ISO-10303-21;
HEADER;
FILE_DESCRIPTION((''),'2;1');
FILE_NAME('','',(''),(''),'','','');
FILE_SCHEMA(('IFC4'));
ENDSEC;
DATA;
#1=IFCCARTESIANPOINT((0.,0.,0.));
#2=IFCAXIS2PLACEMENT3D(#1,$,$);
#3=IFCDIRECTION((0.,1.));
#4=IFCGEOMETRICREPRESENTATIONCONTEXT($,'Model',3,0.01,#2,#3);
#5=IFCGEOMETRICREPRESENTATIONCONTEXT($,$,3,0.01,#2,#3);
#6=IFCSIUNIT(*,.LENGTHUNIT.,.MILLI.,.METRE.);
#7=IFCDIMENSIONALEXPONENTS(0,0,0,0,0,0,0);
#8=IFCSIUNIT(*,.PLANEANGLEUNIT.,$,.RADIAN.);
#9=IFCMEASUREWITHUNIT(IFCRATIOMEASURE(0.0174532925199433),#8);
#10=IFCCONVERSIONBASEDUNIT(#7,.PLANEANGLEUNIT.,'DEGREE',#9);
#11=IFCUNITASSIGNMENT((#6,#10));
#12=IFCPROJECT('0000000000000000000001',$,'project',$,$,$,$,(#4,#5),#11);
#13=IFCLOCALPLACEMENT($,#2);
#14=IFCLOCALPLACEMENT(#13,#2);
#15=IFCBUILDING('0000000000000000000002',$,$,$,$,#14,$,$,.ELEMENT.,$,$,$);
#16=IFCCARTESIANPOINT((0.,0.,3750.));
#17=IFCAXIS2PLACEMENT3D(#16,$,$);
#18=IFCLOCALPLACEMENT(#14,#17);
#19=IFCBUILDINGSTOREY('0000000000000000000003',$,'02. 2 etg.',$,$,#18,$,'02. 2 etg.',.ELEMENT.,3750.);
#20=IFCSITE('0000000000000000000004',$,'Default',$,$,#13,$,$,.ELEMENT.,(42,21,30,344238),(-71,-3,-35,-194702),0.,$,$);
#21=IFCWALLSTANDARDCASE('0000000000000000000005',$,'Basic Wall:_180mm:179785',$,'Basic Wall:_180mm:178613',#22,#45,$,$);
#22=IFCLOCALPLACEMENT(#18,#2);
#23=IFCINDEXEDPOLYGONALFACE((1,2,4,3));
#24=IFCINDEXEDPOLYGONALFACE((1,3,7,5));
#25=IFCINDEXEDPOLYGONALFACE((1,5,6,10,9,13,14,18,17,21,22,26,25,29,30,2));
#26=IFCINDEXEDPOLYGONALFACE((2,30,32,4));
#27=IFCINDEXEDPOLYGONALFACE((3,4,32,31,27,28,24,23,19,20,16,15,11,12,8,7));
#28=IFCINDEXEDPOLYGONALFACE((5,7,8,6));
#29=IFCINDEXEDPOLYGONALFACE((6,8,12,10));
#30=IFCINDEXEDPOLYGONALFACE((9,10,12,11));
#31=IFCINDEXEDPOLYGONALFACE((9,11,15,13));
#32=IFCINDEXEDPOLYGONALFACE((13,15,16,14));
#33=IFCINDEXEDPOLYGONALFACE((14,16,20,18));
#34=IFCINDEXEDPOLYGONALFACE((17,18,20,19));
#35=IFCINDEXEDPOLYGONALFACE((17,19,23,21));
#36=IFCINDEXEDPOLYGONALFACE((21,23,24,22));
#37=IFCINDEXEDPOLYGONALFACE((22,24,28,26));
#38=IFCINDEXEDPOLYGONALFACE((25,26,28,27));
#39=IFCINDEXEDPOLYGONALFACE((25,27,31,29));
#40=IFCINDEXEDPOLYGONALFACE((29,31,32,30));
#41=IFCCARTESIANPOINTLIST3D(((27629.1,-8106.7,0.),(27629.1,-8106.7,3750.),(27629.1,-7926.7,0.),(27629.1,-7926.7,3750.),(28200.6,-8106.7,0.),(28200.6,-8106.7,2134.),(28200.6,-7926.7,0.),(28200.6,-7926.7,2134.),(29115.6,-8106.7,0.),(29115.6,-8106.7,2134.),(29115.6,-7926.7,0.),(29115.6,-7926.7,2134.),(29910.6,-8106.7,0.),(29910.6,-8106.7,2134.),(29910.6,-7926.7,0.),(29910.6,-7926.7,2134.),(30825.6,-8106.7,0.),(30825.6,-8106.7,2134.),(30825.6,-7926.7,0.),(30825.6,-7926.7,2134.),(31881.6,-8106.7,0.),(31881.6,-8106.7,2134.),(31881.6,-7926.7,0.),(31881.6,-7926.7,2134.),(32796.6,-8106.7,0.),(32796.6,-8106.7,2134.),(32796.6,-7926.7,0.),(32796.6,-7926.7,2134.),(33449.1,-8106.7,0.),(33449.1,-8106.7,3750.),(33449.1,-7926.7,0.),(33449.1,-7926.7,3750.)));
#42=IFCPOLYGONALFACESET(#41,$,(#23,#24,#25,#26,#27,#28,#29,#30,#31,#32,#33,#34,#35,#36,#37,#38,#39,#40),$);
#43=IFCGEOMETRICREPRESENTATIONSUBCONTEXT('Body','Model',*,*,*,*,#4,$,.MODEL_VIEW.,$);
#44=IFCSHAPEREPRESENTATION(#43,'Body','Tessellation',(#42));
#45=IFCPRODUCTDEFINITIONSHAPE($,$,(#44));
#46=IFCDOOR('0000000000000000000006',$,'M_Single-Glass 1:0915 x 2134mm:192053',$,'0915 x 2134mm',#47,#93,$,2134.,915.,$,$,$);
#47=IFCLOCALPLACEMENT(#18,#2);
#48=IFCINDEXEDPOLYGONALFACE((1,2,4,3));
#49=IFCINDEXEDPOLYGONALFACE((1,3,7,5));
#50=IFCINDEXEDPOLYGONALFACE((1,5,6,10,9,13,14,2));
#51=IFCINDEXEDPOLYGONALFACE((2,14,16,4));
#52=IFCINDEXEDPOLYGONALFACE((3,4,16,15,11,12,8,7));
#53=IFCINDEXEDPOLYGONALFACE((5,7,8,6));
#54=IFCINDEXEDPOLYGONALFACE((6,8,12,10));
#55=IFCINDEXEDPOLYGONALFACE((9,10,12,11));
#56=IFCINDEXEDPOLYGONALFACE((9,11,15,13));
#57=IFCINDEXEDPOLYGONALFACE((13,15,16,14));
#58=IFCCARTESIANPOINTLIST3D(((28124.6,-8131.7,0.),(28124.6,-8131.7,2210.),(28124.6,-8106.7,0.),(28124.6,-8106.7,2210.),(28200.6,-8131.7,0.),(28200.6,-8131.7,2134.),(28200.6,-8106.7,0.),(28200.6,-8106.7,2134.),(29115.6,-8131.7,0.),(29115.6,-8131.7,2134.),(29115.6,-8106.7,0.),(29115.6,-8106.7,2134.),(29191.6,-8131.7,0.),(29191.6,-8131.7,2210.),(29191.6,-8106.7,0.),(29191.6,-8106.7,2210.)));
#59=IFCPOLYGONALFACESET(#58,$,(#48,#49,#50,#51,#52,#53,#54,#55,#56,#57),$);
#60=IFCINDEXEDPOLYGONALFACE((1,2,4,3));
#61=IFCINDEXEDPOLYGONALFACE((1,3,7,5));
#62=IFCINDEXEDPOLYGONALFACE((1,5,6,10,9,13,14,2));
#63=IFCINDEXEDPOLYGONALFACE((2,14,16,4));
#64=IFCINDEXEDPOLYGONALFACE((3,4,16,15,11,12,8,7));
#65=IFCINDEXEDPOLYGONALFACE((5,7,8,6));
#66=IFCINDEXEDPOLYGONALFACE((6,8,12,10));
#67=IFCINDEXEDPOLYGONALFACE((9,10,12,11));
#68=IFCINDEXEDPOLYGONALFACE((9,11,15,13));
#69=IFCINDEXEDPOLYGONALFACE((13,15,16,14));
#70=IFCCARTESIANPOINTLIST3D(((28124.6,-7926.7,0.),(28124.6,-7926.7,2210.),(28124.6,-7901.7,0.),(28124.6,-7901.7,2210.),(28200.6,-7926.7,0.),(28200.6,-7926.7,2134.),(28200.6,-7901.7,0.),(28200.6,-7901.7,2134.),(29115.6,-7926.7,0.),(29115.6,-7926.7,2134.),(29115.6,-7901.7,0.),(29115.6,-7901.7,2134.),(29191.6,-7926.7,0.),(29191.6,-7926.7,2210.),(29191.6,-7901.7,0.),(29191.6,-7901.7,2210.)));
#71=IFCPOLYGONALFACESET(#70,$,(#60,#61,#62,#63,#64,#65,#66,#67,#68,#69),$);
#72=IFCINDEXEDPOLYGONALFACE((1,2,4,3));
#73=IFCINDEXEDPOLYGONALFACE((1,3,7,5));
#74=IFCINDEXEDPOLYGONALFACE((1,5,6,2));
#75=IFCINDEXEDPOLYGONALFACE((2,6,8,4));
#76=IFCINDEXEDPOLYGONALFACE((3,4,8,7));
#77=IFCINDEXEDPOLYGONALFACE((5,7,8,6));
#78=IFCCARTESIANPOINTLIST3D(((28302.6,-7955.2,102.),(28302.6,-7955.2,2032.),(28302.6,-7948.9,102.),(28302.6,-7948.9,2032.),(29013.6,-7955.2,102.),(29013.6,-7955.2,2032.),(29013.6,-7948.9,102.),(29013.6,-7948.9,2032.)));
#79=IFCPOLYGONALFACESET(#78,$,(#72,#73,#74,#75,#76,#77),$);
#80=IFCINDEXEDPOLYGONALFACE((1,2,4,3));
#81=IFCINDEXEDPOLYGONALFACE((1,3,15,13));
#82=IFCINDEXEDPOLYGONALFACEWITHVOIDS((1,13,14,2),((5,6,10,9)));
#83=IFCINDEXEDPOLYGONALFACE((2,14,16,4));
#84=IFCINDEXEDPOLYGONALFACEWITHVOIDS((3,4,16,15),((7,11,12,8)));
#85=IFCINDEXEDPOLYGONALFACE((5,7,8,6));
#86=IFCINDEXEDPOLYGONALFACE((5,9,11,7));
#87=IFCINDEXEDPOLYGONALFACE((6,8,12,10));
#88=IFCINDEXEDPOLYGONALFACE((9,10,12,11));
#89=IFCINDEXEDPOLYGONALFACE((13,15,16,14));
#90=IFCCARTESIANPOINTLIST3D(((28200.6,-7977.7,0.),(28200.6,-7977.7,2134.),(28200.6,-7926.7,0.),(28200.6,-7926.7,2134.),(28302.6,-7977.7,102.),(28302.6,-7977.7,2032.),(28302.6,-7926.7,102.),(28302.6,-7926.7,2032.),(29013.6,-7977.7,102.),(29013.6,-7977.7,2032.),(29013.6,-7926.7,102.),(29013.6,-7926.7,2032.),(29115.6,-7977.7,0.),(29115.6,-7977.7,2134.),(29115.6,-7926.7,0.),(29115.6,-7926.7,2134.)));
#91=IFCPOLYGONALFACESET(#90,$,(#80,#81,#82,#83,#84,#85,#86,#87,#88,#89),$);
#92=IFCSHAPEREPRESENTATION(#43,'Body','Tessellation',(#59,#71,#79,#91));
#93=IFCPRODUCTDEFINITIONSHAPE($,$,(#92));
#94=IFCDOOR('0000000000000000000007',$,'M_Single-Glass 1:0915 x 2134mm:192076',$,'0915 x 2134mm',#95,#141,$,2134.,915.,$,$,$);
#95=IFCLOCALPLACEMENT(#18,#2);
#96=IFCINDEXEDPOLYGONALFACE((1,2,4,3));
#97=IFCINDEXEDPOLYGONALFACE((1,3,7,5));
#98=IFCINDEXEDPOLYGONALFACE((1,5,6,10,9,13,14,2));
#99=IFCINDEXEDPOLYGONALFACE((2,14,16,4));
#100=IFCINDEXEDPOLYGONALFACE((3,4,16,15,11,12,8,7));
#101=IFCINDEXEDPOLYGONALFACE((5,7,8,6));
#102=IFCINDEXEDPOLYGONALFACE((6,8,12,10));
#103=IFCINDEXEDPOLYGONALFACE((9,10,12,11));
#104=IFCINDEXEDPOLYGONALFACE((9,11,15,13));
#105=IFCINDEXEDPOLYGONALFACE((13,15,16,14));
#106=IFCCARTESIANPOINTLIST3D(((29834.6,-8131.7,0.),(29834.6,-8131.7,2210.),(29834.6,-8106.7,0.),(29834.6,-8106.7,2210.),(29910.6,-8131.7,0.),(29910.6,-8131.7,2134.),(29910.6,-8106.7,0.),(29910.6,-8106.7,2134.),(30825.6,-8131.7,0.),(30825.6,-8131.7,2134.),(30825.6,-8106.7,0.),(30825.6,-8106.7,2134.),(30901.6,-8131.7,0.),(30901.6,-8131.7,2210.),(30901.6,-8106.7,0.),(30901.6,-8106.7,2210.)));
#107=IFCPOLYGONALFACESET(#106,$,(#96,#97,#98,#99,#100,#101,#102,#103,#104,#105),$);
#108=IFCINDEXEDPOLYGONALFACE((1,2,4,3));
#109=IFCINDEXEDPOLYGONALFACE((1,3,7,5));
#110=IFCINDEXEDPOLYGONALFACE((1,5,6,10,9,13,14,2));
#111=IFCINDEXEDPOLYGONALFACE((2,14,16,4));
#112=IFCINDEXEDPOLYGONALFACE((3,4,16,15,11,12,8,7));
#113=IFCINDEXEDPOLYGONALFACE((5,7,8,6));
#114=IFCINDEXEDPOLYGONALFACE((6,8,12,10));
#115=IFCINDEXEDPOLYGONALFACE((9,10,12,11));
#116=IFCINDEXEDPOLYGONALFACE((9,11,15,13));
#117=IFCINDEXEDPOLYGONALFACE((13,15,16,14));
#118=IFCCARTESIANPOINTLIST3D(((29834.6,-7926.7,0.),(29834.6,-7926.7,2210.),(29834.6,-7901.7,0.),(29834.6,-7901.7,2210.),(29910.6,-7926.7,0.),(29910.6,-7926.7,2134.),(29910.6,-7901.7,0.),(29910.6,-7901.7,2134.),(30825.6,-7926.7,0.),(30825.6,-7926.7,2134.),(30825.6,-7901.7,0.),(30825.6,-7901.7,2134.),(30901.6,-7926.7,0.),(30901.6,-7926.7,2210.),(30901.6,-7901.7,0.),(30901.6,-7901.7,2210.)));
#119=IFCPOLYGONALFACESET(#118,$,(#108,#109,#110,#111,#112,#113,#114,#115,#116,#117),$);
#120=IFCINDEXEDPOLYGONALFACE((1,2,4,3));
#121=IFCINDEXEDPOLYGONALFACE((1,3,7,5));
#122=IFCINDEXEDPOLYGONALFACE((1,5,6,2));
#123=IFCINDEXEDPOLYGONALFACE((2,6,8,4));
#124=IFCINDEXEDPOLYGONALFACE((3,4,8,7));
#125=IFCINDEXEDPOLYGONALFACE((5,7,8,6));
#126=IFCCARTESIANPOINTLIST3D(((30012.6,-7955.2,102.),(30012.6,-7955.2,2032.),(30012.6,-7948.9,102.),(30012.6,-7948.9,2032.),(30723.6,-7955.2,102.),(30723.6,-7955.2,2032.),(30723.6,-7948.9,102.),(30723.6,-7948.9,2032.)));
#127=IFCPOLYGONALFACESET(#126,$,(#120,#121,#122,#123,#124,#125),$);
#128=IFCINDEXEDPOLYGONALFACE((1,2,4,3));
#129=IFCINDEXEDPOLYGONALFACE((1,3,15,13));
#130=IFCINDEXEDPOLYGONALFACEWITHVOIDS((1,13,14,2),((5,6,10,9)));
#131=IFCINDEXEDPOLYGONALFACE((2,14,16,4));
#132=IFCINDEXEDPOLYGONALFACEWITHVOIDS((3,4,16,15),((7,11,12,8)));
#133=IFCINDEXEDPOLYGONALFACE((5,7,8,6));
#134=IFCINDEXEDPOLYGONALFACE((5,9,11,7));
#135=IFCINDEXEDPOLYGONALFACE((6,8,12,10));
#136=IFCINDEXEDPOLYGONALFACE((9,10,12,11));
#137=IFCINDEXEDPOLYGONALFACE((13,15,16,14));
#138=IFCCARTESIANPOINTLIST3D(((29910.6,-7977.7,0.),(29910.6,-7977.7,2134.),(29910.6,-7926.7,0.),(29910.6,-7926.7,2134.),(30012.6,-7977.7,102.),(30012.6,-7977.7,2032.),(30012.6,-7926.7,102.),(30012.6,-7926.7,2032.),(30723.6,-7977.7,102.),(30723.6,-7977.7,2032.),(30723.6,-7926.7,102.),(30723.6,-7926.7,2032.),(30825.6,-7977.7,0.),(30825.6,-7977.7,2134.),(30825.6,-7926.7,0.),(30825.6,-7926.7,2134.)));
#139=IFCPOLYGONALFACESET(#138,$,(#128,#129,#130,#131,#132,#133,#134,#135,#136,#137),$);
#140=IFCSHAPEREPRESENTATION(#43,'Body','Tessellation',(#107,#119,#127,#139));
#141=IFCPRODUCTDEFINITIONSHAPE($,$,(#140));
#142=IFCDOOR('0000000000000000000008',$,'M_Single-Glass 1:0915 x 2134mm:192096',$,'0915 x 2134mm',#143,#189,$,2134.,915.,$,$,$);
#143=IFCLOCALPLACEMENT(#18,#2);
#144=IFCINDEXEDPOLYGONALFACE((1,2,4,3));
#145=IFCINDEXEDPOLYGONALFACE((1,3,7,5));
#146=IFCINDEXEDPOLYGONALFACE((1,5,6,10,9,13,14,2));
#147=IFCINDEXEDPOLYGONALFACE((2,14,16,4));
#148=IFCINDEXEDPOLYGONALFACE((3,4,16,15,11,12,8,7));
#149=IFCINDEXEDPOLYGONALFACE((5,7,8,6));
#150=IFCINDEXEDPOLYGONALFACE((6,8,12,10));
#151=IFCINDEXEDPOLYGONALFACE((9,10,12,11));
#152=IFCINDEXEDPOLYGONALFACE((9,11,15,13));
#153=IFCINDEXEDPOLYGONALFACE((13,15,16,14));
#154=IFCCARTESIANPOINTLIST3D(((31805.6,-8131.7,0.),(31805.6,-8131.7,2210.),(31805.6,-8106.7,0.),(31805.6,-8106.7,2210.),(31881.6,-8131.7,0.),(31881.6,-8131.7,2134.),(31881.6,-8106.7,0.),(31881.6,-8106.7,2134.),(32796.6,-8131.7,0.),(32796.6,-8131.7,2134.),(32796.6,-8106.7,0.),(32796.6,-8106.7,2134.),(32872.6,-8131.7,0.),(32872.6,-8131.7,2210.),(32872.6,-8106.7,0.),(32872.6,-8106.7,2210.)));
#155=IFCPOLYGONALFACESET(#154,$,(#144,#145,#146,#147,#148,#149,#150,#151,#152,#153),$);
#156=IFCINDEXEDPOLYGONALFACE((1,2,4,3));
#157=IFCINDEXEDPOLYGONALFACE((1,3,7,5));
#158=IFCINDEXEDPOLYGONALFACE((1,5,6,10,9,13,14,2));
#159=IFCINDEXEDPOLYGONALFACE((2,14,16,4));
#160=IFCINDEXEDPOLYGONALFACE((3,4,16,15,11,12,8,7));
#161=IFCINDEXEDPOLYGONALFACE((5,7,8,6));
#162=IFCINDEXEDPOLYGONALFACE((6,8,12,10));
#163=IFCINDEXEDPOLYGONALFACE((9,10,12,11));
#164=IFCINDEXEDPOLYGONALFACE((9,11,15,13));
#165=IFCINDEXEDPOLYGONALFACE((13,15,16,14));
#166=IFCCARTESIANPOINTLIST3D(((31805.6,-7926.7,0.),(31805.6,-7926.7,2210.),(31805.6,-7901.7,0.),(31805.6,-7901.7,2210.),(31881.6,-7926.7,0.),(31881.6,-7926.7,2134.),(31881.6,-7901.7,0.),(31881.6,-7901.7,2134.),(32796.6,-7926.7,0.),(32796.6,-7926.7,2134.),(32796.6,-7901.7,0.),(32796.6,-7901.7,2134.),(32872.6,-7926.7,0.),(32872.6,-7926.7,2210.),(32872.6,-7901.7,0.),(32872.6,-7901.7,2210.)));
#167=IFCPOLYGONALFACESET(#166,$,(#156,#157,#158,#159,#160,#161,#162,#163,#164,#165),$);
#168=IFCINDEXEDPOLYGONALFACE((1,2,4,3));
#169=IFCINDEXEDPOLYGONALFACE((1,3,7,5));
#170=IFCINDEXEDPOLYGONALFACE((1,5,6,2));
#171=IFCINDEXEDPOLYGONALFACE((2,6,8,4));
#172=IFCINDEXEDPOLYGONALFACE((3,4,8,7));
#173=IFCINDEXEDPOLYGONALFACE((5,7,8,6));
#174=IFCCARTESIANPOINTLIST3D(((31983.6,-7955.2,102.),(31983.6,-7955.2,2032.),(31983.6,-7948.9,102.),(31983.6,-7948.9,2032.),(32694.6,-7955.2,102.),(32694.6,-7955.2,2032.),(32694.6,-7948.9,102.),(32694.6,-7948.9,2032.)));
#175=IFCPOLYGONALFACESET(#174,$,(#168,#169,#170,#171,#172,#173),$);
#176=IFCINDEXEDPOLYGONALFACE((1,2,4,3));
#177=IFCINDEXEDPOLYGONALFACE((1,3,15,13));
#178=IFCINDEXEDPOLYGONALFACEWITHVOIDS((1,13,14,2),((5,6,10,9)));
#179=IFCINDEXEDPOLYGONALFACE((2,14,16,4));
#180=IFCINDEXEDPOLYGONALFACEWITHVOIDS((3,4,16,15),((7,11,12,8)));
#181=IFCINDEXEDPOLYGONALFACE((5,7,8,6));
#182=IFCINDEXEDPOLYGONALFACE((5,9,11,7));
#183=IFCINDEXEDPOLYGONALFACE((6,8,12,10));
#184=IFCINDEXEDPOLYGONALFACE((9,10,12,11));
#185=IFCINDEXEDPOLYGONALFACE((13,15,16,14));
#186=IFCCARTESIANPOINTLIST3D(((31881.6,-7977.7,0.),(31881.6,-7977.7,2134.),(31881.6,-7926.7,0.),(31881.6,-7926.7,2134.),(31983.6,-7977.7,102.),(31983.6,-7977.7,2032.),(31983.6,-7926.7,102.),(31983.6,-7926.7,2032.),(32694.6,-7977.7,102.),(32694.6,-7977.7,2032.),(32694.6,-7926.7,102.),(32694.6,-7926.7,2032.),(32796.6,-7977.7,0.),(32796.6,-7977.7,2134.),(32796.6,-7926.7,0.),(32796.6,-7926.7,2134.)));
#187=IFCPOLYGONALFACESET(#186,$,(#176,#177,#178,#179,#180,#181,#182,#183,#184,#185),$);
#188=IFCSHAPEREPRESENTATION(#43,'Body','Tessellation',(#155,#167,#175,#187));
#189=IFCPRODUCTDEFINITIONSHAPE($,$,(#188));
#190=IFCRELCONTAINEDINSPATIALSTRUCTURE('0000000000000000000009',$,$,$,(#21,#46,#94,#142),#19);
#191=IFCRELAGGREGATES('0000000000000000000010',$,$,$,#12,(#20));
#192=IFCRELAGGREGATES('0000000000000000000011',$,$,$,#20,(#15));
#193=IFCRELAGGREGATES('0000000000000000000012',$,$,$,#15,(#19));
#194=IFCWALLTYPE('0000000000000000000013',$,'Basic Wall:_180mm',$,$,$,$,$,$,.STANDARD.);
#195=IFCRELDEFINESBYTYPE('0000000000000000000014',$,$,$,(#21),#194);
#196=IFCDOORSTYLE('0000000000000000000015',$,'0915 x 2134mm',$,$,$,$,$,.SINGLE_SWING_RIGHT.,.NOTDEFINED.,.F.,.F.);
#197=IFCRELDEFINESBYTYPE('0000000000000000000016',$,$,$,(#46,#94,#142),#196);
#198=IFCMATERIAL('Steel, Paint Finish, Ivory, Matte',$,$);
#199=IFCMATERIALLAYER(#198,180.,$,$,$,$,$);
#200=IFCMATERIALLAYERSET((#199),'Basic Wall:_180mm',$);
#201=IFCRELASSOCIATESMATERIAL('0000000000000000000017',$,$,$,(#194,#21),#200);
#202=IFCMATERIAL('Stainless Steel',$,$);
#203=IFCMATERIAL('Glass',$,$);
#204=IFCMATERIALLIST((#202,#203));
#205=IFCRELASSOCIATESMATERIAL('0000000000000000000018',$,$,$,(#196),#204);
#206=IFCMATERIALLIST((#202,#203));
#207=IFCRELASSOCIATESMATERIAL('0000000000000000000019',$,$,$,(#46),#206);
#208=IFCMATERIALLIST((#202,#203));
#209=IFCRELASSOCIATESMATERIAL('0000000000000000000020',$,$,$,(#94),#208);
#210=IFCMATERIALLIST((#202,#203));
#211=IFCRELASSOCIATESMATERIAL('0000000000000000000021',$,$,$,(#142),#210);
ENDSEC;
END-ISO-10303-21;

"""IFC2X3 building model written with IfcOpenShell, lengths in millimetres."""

from ifc_helpers import new_model, entity, si_unit, converted_unit, direction, frame, frame_2d, origin, place, context, subcontext, project, spatial, polyline, rectangle, outline, extrude, source, transform, mapped, material, material_list, layer, layer_set, layer_usage, type_object, type_shapes, element, fill, save


model = new_model("IFC2X3")

# Units and contexts
model_context = context("Model", 3, precision=0.01, world=origin(), true_north=direction((0.0, 1.0)))
context_of_model = context(None, 3, precision=0.01, world=origin(), true_north=direction((0.0, 1.0)))
body_context = subcontext(model_context, "Body", "Model", "MODEL_VIEW")
ifc_project = project(units=[si_unit("LENGTHUNIT", "METRE", prefix="MILLI"), converted_unit("PLANEANGLEUNIT", "DEGREE", entity("IfcRatioMeasure", 0.0174532925199433), si_unit("PLANEANGLEUNIT", "RADIAN"), dimensions=[0, 0, 0, 0, 0, 0, 0])], contexts=[model_context, context_of_model])

# Site, building, storey
site_placement = place(None, origin())
site = spatial("IfcSite", under=ifc_project, at=site_placement, Name="Default", CompositionType="ELEMENT", RefLatitude=(42, 21, 30, 344238), RefLongitude=(-71, -3, -35, -194702), RefElevation=0.0)
building_placement = place(site_placement, origin())
building = spatial("IfcBuilding", under=site, at=building_placement, CompositionType="ELEMENT")
storey_placement = place(building_placement, frame((0.0, 0.0, 3750.0)))
storey = spatial("IfcBuildingStorey", under=building, at=storey_placement, Name="02. 2 etg.", LongName="02. 2 etg.", CompositionType="ELEMENT", Elevation=3750.0)

# Shared definitions
ifc_material_1 = material(Name="Glass")

# Shared definitions
ifc_material_2 = material(Name="Stainless Steel")

# Shared definitions
ifc_material_3 = material(Name="Steel, Paint Finish, Ivory, Matte")

# Shared definitions
ifc_layer_1 = layer(ifc_material_3, 180.0)
ifc_layer_set_1 = layer_set([ifc_layer_1], Name="Basic Wall:_180mm")
wall_type_1 = type_object("IfcWallType", Name="Basic Wall:_180mm", PredefinedType="STANDARD", material=ifc_layer_set_1)

# Wall, openings, doors
ifc_layer_usage_1 = layer_usage(ifc_layer_set_1, "AXIS2", "POSITIVE", -90.0)
wall_1_placement = place(storey_placement, frame((27629.1, -8016.7, 0.0)))
wall_1 = element("IfcWallStandardCase", 1, at=wall_1_placement, inside=storey, type_object=wall_type_1, material=ifc_layer_usage_1, Name="Basic Wall:_180mm:179785", ObjectType="Basic Wall:_180mm:178613", context=body_context, shape_type="SweptSolid", body=[
    extrude(rectangle(XDim=5820.0, YDim=180.0, at=frame_2d((2910.0, 0.0), x_axis=(-1.0, 0.0))), origin(), (0.0, 0.0, 1.0), 3750.0),
])
opening_1_placement = place(wall_1_placement, frame((571.5, -90.0, 0.0)))
opening_1 = element("IfcOpeningElement", 2, at=opening_1_placement, cuts=wall_1, ObjectType="Opening", context=body_context, shape_type="SweptSolid", body=[
    extrude(rectangle(XDim=915.0, YDim=2134.0, at=frame_2d((1067.0, 457.5), x_axis=(0.0, 1.0))), frame((0.0, 0.0, 0.0), z_axis=(0.0, 1.0, 0.0), x_axis=(0.0, 0.0, 1.0)), (0.0, 0.0, 1.0), 180.0),
])
opening_2_placement = place(wall_1_placement, frame((2281.5, -90.0, 0.0)))
opening_2 = element("IfcOpeningElement", 3, at=opening_2_placement, cuts=wall_1, ObjectType="Opening", context=body_context, shape_type="SweptSolid", body=[
    extrude(rectangle(XDim=915.0, YDim=2134.0, at=frame_2d((1067.0, 457.5), x_axis=(0.0, 1.0))), frame((0.0, 0.0, 0.0), z_axis=(0.0, 1.0, 0.0), x_axis=(0.0, 0.0, 1.0)), (0.0, 0.0, 1.0), 180.0),
])
opening_3_placement = place(wall_1_placement, frame((4252.5, -90.0, 0.0)))
opening_3 = element("IfcOpeningElement", 4, at=opening_3_placement, cuts=wall_1, ObjectType="Opening", context=body_context, shape_type="SweptSolid", body=[
    extrude(rectangle(XDim=915.0, YDim=2134.0, at=frame_2d((1067.0, 457.5), x_axis=(0.0, 1.0))), frame((0.0, 0.0, 0.0), z_axis=(0.0, 1.0, 0.0), x_axis=(0.0, 0.0, 1.0)), (0.0, 0.0, 1.0), 180.0),
])
ifc_material_list_1 = material_list([ifc_material_2, ifc_material_1])
ifc_material_list_2 = material_list([ifc_material_2, ifc_material_1])
door_style_1 = type_object("IfcDoorStyle", Name="0915 x 2134mm", ConstructionType="NOTDEFINED", OperationType="SINGLE_SWING_RIGHT", ParameterTakesPrecedence=False, Sizeable=False, material=ifc_material_list_2)
shared_shape_1 = source(origin(), body_context, "Body", "SweptSolid", [
    extrude(outline(polyline([(-457.5, -1048.0), (-457.5, 1086.0), (-533.5, 1086.0), (-533.5, -1124.0), (533.5, -1124.0), (533.5, 1086.0), (457.5, 1086.0), (457.5, -1048.0), (-457.5, -1048.0)])), frame((457.5, -25.0, 1086.0), z_axis=(0.0, -1.0, 0.0), x_axis=(-1.0, 0.0, 0.0)), (0.0, 0.0, -1.0), 25.0),
    extrude(outline(polyline([(-457.5, -1048.0), (-457.5, 1086.0), (-533.5, 1086.0), (-533.5, -1124.0), (533.5, -1124.0), (533.5, 1086.0), (457.5, 1086.0), (457.5, -1048.0), (-457.5, -1048.0)])), frame((457.5, 180.0, 1086.0), z_axis=(0.0, -1.0, 0.0), x_axis=(-1.0, 0.0, 0.0)), (0.0, 0.0, -1.0), 25.0),
    extrude(rectangle(XDim=6.3, YDim=711.0, at=frame_2d((0.0, 0.0), x_axis=(1.0, 0.0))), frame((457.5, 154.6, 102.0), z_axis=(0.0, 0.0, 1.0), x_axis=(0.0, 1.0, 0.0)), (0.0, 0.0, 1.0), 1930.0),
    extrude(outline(polyline([(-1067.0, -457.5), (1067.0, -457.5), (1067.0, 457.5), (-1067.0, 457.5), (-1067.0, -457.5)]), holes=[polyline([(-965.0, 355.5), (965.0, 355.5), (965.0, -355.5), (-965.0, -355.5), (-965.0, 355.5)])]), frame((457.5, 129.0, 1067.0), z_axis=(0.0, 1.0, 0.0), x_axis=(0.0, 0.0, -1.0)), (0.0, 0.0, 1.0), 51.0),
])
type_shapes(door_style_1, [shared_shape_1])
door_1_placement = place(opening_1_placement, origin())
door_1 = element("IfcDoor", 5, at=door_1_placement, inside=storey, type_object=door_style_1, material=ifc_material_list_1, Name="M_Single-Glass 1:0915 x 2134mm:192053", ObjectType="0915 x 2134mm", OverallHeight=2134.0, OverallWidth=915.0, context=body_context, shape_type="MappedRepresentation", body=[
    mapped(shared_shape_1, transform((0.0, 0.0, 0.0), scale=1.0)),
])
fill(opening_1, door_1)
ifc_material_list_3 = material_list([ifc_material_2, ifc_material_1])
door_2_placement = place(opening_2_placement, origin())
door_2 = element("IfcDoor", 6, at=door_2_placement, inside=storey, type_object=door_style_1, material=ifc_material_list_3, Name="M_Single-Glass 1:0915 x 2134mm:192076", ObjectType="0915 x 2134mm", OverallHeight=2134.0, OverallWidth=915.0, context=body_context, shape_type="MappedRepresentation", body=[
    mapped(shared_shape_1, transform((0.0, 0.0, 0.0), scale=1.0)),
])
fill(opening_2, door_2)
ifc_material_list_4 = material_list([ifc_material_2, ifc_material_1])
door_3_placement = place(opening_3_placement, origin())
door_3 = element("IfcDoor", 7, at=door_3_placement, inside=storey, type_object=door_style_1, material=ifc_material_list_4, Name="M_Single-Glass 1:0915 x 2134mm:192096", ObjectType="0915 x 2134mm", OverallHeight=2134.0, OverallWidth=915.0, context=body_context, shape_type="MappedRepresentation", body=[
    mapped(shared_shape_1, transform((0.0, 0.0, 0.0), scale=1.0)),
])
fill(opening_3, door_3)

save(model, "model.ifc")
